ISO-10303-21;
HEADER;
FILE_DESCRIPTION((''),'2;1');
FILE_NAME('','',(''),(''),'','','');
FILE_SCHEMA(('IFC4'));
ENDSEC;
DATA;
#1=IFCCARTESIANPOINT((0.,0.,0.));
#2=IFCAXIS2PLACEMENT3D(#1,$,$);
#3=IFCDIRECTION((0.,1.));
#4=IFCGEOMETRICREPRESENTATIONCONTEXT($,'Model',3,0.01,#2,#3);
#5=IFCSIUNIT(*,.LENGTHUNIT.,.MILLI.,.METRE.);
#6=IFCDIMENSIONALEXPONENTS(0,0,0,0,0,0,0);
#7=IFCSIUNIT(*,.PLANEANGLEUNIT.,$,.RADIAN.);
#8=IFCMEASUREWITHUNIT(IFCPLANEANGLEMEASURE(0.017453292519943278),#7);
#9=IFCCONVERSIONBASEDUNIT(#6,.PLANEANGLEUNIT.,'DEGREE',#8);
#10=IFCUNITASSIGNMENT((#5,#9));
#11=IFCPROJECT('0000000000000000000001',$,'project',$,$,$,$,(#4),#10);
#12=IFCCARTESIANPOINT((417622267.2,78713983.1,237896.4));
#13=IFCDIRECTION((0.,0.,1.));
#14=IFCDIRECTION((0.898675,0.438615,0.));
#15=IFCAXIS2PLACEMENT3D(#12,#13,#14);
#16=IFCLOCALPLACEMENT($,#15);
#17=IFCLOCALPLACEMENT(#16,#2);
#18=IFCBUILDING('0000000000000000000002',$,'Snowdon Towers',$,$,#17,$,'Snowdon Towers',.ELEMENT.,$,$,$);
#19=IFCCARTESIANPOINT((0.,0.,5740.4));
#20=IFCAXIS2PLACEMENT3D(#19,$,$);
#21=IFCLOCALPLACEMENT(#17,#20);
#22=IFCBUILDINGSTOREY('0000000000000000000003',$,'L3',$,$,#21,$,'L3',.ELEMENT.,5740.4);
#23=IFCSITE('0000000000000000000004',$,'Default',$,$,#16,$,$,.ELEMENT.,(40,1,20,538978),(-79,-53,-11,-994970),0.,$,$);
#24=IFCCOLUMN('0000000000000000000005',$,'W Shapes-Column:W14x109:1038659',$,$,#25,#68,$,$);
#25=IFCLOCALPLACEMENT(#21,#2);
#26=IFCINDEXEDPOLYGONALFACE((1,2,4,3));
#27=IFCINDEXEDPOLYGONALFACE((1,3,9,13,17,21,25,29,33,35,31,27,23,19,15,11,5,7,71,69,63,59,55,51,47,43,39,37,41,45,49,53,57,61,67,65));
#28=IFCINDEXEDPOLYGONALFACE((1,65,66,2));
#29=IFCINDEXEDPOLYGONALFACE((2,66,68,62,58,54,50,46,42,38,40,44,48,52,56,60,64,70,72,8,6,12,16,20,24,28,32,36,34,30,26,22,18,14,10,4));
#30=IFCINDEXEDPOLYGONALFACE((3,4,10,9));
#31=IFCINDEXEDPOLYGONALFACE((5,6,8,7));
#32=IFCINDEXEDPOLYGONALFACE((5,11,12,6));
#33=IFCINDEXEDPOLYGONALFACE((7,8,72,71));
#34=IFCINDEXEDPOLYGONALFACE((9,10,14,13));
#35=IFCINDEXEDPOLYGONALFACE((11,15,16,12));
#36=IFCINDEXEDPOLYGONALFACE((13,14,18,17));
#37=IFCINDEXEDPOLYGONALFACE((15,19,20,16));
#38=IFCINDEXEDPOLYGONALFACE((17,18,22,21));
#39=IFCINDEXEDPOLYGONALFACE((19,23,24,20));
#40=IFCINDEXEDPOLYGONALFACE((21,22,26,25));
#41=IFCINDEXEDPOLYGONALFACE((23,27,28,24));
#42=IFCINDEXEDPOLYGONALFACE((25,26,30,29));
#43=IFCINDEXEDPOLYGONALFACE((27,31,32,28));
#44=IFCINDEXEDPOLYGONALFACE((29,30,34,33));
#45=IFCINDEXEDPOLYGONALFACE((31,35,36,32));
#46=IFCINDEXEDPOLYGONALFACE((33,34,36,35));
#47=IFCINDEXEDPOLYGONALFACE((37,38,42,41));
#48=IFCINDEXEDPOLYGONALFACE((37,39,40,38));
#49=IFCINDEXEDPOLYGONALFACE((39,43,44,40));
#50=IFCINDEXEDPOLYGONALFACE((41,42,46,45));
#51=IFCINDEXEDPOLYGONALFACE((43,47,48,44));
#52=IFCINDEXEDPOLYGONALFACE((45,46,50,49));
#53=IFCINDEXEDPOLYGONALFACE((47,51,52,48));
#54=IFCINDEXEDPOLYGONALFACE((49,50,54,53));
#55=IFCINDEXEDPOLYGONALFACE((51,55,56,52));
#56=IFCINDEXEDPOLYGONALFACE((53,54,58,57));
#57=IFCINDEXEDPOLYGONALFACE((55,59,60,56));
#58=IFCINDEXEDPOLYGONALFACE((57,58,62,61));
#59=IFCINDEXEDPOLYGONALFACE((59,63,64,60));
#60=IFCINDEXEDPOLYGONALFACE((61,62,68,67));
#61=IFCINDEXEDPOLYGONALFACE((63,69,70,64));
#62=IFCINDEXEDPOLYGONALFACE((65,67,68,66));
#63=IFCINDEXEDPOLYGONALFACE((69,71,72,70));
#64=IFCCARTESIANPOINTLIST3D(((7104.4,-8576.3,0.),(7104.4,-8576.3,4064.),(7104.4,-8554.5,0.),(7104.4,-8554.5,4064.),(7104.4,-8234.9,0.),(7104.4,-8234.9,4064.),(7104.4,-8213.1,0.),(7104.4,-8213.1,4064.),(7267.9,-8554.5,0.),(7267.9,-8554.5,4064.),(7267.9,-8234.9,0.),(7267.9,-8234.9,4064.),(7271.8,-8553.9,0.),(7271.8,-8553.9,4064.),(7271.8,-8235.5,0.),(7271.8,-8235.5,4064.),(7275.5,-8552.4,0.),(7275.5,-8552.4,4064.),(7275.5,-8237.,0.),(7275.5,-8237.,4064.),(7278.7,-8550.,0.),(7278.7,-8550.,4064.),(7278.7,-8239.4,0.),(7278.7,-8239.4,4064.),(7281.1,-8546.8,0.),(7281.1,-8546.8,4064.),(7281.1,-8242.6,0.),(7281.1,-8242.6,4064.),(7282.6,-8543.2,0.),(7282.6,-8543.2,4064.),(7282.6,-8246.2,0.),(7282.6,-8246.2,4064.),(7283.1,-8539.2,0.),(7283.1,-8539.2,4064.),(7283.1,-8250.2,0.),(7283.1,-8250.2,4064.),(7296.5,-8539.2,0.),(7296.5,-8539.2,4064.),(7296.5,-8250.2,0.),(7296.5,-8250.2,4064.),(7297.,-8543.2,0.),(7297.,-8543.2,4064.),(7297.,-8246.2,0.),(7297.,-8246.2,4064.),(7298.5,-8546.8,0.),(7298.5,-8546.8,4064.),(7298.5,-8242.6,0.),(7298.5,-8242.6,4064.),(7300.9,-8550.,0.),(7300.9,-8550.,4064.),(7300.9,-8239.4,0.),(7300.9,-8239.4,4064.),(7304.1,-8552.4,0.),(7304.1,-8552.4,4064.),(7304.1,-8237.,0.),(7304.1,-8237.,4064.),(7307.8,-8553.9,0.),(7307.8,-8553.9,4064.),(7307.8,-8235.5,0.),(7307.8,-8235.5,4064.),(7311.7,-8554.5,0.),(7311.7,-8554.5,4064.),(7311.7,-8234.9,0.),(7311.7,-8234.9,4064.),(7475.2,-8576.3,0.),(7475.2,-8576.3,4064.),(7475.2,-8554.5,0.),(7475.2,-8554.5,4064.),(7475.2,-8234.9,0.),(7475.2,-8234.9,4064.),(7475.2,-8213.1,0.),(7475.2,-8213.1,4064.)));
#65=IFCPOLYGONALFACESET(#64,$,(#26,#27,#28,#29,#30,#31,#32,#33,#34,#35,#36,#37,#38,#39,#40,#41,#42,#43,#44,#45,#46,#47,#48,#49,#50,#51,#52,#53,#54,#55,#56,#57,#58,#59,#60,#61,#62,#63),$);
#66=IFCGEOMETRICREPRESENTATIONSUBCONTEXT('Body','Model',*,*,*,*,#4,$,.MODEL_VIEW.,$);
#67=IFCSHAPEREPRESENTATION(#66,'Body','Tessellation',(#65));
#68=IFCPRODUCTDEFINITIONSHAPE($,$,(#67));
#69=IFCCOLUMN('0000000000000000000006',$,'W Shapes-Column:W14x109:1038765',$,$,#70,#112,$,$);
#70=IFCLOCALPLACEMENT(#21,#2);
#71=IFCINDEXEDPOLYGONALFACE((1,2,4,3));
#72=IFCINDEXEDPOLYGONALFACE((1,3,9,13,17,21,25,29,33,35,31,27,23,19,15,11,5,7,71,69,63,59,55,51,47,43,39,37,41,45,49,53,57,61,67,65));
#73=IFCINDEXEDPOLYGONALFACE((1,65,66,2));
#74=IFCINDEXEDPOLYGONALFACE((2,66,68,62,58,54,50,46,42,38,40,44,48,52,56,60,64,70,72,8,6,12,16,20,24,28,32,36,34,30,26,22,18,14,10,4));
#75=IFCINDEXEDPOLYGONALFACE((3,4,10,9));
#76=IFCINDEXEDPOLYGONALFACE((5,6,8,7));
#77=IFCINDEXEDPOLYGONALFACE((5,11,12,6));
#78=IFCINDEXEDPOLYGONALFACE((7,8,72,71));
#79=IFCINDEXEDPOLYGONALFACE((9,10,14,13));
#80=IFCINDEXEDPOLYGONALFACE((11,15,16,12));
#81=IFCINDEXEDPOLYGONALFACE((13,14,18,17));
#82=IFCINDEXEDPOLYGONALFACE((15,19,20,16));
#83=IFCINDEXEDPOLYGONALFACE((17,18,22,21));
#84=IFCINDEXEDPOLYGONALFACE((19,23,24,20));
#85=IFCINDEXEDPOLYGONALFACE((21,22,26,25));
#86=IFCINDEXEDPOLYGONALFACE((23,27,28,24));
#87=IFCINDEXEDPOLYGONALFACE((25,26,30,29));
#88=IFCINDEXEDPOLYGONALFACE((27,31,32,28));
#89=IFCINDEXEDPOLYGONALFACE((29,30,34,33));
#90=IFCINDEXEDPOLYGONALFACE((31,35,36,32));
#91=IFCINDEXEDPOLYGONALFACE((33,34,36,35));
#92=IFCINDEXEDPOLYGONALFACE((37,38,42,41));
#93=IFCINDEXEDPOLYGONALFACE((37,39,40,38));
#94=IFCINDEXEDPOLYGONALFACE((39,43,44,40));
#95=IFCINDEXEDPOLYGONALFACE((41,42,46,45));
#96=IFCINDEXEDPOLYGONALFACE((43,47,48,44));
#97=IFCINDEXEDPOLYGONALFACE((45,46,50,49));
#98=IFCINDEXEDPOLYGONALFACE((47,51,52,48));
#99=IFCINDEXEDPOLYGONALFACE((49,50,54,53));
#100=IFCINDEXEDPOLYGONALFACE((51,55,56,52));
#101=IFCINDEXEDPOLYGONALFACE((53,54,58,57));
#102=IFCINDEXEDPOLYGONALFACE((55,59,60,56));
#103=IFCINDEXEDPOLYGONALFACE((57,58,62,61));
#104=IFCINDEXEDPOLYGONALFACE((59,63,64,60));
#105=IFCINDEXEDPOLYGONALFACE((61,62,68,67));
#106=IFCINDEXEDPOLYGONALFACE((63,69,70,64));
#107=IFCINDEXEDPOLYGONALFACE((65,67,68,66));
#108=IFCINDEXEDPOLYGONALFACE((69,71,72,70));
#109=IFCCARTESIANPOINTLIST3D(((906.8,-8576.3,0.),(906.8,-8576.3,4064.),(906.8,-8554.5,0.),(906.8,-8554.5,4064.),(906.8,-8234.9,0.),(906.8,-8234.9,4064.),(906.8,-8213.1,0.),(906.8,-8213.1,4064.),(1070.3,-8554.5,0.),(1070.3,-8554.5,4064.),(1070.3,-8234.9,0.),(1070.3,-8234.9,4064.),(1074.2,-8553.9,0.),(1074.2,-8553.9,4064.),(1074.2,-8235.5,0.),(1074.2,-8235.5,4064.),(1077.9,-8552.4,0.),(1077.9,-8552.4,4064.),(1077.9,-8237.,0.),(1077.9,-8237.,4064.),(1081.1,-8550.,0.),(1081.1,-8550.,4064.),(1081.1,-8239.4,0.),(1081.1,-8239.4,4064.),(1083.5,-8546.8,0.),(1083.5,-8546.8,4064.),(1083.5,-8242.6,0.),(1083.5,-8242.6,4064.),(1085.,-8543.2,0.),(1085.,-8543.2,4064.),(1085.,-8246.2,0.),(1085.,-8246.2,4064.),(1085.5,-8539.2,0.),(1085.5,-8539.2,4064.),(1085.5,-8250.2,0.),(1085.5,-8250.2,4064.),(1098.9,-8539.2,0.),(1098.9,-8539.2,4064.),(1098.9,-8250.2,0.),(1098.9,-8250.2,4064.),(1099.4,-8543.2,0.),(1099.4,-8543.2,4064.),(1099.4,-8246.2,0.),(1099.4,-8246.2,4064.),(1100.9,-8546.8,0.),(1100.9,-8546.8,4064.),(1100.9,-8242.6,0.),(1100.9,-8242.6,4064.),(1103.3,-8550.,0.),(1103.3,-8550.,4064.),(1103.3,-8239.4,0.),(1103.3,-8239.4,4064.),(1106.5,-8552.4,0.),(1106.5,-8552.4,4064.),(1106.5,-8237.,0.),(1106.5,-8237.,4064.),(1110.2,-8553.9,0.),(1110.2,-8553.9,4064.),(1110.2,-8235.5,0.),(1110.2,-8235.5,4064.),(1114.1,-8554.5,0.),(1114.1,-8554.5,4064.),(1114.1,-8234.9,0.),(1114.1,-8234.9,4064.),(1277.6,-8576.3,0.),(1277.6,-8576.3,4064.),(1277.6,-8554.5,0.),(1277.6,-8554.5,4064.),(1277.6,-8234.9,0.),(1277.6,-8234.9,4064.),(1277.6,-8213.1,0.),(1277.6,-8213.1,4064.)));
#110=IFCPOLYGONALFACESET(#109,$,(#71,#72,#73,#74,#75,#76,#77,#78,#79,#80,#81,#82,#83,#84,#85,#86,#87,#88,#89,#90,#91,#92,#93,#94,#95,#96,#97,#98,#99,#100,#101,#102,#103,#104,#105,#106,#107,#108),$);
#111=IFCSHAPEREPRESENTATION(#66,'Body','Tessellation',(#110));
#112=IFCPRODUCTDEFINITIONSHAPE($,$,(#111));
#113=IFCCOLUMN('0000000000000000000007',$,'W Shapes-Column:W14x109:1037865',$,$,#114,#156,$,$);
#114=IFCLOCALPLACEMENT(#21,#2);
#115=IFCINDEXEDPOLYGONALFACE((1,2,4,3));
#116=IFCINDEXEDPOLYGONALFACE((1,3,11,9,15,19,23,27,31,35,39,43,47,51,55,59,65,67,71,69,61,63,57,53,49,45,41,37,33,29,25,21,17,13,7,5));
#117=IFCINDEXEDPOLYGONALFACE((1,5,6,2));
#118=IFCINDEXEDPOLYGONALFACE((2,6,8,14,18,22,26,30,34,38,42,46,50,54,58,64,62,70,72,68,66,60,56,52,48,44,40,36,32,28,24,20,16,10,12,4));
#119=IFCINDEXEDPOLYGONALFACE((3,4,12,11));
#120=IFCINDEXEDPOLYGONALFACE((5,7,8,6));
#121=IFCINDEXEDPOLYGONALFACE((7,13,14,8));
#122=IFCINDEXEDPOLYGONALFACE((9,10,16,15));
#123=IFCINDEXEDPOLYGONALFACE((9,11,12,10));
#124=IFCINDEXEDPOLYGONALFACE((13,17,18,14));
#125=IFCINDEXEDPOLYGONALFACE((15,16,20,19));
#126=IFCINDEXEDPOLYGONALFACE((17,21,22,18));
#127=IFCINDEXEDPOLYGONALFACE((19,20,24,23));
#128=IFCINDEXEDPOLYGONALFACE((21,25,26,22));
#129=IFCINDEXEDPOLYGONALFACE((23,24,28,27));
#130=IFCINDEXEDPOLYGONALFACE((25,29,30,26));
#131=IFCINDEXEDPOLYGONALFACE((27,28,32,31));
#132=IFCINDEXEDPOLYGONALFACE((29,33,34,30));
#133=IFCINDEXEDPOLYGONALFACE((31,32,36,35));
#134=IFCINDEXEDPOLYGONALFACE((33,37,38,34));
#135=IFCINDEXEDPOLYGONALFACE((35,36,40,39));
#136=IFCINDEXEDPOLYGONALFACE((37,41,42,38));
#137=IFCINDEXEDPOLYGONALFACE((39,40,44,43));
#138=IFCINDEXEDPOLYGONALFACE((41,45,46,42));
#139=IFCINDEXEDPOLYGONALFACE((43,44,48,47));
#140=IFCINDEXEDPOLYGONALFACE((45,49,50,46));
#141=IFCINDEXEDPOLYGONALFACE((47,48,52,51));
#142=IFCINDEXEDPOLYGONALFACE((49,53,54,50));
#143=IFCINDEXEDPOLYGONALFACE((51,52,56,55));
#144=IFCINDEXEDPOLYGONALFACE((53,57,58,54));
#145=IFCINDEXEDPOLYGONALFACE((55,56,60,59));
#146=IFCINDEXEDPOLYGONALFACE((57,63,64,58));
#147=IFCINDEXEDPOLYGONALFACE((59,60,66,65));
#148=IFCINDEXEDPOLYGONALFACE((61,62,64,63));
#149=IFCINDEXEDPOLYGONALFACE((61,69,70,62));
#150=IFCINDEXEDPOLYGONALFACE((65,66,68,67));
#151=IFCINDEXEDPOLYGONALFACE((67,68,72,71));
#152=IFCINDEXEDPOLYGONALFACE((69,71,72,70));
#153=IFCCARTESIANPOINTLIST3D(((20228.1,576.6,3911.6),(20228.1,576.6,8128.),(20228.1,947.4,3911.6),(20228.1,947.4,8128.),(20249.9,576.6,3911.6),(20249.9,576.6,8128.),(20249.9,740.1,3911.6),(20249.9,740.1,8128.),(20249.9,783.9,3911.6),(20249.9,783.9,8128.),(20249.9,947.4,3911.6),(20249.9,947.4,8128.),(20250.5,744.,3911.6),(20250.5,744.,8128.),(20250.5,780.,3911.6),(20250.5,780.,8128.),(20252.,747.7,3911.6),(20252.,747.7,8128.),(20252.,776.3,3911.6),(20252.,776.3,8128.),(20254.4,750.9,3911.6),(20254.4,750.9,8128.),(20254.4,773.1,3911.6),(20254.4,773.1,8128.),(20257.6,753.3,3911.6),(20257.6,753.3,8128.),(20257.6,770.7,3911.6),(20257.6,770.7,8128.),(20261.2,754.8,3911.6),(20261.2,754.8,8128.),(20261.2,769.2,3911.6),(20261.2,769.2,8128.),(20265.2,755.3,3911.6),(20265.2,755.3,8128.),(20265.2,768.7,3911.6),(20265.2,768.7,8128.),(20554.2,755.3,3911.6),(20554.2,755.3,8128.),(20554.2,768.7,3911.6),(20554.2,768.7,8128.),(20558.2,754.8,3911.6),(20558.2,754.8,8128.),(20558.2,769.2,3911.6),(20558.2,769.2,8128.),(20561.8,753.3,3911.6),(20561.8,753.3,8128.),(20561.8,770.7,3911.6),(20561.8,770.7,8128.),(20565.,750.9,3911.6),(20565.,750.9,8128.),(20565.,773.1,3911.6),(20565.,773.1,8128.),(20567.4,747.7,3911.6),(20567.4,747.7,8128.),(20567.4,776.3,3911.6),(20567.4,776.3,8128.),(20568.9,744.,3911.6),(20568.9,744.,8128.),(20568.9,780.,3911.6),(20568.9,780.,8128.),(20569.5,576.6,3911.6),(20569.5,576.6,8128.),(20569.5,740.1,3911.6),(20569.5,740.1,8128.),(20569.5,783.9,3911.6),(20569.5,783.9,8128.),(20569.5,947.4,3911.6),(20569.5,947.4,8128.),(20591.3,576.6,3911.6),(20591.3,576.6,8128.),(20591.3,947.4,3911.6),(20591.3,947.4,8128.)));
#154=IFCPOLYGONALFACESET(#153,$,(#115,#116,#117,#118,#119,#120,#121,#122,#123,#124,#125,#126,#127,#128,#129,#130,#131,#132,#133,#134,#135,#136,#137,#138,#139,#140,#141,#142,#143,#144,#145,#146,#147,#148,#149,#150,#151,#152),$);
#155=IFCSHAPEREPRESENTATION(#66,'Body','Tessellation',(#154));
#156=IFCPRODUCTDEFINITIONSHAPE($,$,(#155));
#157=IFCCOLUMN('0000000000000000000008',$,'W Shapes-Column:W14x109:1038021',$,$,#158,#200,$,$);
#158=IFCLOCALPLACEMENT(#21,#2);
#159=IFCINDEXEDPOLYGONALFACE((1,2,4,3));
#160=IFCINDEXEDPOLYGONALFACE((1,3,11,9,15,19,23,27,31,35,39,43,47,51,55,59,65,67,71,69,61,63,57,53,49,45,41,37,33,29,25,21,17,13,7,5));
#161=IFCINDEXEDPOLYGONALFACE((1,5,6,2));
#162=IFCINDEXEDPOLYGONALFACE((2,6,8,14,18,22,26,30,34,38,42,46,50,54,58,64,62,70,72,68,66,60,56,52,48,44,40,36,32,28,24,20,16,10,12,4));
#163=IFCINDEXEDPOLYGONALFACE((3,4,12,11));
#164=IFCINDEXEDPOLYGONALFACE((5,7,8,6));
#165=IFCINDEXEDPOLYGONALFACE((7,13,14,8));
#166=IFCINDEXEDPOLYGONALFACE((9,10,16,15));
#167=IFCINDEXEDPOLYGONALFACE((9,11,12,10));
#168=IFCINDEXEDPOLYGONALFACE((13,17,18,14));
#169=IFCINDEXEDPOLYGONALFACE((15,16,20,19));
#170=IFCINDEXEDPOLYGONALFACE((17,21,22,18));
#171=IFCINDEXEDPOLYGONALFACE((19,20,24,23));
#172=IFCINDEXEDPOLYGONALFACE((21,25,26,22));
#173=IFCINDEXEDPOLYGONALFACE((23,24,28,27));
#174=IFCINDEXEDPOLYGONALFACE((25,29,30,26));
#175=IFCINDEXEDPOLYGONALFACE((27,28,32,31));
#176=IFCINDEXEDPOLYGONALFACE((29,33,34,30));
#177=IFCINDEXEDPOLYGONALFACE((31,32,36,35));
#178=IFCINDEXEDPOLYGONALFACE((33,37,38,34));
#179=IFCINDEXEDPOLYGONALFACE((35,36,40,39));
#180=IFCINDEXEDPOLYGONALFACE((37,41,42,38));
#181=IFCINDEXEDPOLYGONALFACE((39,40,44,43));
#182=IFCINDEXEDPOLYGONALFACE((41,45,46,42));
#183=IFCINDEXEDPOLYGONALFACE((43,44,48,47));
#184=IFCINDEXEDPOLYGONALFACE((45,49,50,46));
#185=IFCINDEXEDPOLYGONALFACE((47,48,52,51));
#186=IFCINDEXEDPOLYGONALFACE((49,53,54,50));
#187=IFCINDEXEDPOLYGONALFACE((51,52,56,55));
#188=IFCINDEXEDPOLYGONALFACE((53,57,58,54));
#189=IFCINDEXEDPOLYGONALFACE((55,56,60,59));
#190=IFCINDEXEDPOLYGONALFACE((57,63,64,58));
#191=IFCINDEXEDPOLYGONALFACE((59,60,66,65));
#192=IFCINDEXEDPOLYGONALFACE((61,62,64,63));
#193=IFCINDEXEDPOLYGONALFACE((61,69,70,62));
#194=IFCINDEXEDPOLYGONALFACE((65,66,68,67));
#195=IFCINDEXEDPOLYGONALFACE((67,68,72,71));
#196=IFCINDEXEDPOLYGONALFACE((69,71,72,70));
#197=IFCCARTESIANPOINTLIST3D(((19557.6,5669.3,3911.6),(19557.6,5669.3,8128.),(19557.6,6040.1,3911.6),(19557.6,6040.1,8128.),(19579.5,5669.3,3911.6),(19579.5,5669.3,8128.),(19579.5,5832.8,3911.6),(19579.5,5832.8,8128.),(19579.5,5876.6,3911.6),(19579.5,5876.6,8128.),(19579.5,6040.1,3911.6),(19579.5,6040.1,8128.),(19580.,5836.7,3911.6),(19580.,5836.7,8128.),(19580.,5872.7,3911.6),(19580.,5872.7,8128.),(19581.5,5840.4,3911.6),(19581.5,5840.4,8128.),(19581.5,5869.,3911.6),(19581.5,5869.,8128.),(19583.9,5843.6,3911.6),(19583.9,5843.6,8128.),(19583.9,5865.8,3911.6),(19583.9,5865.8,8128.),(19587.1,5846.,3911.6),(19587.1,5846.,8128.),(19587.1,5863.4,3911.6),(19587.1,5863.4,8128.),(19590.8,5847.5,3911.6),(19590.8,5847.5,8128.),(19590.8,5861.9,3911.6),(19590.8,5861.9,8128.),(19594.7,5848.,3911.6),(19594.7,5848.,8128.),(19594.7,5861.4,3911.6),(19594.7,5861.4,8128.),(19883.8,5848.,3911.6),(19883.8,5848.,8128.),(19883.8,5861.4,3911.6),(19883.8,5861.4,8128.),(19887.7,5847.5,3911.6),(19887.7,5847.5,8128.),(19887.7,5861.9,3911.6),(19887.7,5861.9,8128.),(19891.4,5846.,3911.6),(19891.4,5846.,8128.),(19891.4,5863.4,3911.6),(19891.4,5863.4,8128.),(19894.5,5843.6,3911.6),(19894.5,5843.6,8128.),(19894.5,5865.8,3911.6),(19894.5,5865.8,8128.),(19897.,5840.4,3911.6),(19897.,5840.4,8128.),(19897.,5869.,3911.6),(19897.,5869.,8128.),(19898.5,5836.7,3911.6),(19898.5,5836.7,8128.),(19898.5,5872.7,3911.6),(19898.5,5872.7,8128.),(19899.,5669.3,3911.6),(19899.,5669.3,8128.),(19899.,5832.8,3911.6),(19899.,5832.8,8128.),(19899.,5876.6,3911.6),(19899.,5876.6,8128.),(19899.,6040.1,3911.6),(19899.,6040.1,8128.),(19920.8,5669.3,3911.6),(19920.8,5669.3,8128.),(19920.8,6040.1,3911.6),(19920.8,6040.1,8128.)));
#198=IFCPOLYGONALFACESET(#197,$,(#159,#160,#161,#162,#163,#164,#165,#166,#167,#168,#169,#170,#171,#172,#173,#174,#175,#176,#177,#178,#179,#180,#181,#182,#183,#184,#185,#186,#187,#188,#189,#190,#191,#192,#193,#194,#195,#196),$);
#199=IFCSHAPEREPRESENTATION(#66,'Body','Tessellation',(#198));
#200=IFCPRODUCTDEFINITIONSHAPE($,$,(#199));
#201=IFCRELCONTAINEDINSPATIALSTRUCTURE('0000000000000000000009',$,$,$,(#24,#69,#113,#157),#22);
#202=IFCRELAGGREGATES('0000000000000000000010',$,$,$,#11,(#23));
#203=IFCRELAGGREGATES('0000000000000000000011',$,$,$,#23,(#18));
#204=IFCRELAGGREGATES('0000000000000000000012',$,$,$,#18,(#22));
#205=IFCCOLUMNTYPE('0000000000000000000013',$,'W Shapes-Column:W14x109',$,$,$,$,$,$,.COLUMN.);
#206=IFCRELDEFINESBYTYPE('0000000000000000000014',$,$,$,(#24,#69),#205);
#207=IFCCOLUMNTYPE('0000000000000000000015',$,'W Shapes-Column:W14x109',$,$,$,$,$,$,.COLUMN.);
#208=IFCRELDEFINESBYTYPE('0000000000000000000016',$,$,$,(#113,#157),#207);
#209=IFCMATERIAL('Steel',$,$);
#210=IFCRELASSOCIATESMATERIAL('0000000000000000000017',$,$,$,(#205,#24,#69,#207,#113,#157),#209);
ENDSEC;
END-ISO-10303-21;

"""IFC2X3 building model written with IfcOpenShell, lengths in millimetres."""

from ifc_helpers import new_model, entity, si_unit, converted_unit, direction, frame, frame_2d, origin, place, context, subcontext, project, spatial, i_section, extrude, source, transform, mapped, material, type_object, type_shapes, element, save


model = new_model("IFC2X3")

# Units and contexts
model_context = context("Model", 3, precision=0.01, world=origin(), true_north=direction((0.0, 1.0)))
body_context = subcontext(model_context, "Body", "Model", "MODEL_VIEW")
ifc_project = project(units=[si_unit("LENGTHUNIT", "METRE", prefix="MILLI"), converted_unit("PLANEANGLEUNIT", "DEGREE", entity("IfcPlaneAngleMeasure", 0.017453292519943278), si_unit("PLANEANGLEUNIT", "RADIAN"), dimensions=[0, 0, 0, 0, 0, 0, 0])], contexts=[model_context])

# Site, building, storey
site_placement = place(None, frame((417622267.2, 78713983.1, 237896.4), z_axis=(0.0, 0.0, 1.0), x_axis=(0.898675, 0.438615, 0.0)))
site = spatial("IfcSite", under=ifc_project, at=site_placement, Name="Default", CompositionType="ELEMENT", RefLatitude=(40, 1, 20, 538978), RefLongitude=(-79, -53, -11, -994970), RefElevation=0.0)
building_placement = place(site_placement, origin())
building = spatial("IfcBuilding", under=site, at=building_placement, Name="Snowdon Towers", LongName="Snowdon Towers", CompositionType="ELEMENT")
storey_placement = place(building_placement, frame((0.0, 0.0, 5740.4)))
storey = spatial("IfcBuildingStorey", under=building, at=storey_placement, Name="L3", LongName="L3", CompositionType="ELEMENT", Elevation=5740.4)

# Columns
ifc_material_1 = material(Name="Steel")
column_type_1 = type_object("IfcColumnType", Name="W Shapes-Column:W14x109", PredefinedType="COLUMN", material=ifc_material_1)
shared_shape_1 = source(origin(), body_context, "Body", "SweptSolid", [
    extrude(i_section(OverallWidth=370.8, OverallDepth=363.2, WebThickness=13.3, FlangeThickness=21.8, FilletRadius=15.2, at=frame_2d((0.0, 0.0), x_axis=(1.0, 0.0))), frame((0.0, 0.0, 5740.4), z_axis=(0.0, 0.0, 1.0), x_axis=(-1.0, 0.0, 0.0)), (0.0, 0.0, 1.0), 4064.0),
])
type_shapes(column_type_1, [shared_shape_1])
for number, where, z_axis, x_axis, name in (
    (1, (7289.8, -8394.7, -5740.4), (0.0, 0.0, 1.0), (-1.0, 0.0, 0.0), "W Shapes-Column:W14x109:1038659"),
    (2, (1092.2, -8394.7, -5740.4), (0.0, 0.0, 1.0), (-1.0, 0.0, 0.0), "W Shapes-Column:W14x109:1038765"),
):
    element("IfcColumn", number, at=place(storey_placement, frame(where, z_axis=z_axis, x_axis=x_axis)), inside=storey, type_object=column_type_1, material=ifc_material_1, Name=name, context=body_context, shape_type="MappedRepresentation", body=[
        mapped(shared_shape_1, transform((0.0, 0.0, 0.0), scale=1.0)),
    ])
column_type_2 = type_object("IfcColumnType", Name="W Shapes-Column:W14x109", PredefinedType="COLUMN", material=ifc_material_1)
shared_shape_2 = source(origin(), body_context, "Body", "SweptSolid", [
    extrude(i_section(OverallWidth=370.8, OverallDepth=363.2, WebThickness=13.3, FlangeThickness=21.8, FilletRadius=15.2, at=frame_2d((0.0, 0.0), x_axis=(1.0, 0.0))), frame((0.0, 0.0, 9652.0), z_axis=(0.0, 0.0, 1.0), x_axis=(-1.0, 0.0, 0.0)), (0.0, 0.0, 1.0), 4216.4),
])
type_shapes(column_type_2, [shared_shape_2])
for number, where, z_axis, x_axis, name in (
    (3, (20409.7, 762.0, -5740.4), (0.0, 0.0, 1.0), (0.0, 1.0, 0.0), "W Shapes-Column:W14x109:1037865"),
    (4, (19739.2, 5854.7, -5740.4), (0.0, 0.0, 1.0), (0.0, 1.0, 0.0), "W Shapes-Column:W14x109:1038021"),
):
    element("IfcColumn", number, at=place(storey_placement, frame(where, z_axis=z_axis, x_axis=x_axis)), inside=storey, type_object=column_type_2, material=ifc_material_1, Name=name, context=body_context, shape_type="MappedRepresentation", body=[
        mapped(shared_shape_2, transform((0.0, 0.0, 0.0), scale=1.0)),
    ])

save(model, "model.ifc")
